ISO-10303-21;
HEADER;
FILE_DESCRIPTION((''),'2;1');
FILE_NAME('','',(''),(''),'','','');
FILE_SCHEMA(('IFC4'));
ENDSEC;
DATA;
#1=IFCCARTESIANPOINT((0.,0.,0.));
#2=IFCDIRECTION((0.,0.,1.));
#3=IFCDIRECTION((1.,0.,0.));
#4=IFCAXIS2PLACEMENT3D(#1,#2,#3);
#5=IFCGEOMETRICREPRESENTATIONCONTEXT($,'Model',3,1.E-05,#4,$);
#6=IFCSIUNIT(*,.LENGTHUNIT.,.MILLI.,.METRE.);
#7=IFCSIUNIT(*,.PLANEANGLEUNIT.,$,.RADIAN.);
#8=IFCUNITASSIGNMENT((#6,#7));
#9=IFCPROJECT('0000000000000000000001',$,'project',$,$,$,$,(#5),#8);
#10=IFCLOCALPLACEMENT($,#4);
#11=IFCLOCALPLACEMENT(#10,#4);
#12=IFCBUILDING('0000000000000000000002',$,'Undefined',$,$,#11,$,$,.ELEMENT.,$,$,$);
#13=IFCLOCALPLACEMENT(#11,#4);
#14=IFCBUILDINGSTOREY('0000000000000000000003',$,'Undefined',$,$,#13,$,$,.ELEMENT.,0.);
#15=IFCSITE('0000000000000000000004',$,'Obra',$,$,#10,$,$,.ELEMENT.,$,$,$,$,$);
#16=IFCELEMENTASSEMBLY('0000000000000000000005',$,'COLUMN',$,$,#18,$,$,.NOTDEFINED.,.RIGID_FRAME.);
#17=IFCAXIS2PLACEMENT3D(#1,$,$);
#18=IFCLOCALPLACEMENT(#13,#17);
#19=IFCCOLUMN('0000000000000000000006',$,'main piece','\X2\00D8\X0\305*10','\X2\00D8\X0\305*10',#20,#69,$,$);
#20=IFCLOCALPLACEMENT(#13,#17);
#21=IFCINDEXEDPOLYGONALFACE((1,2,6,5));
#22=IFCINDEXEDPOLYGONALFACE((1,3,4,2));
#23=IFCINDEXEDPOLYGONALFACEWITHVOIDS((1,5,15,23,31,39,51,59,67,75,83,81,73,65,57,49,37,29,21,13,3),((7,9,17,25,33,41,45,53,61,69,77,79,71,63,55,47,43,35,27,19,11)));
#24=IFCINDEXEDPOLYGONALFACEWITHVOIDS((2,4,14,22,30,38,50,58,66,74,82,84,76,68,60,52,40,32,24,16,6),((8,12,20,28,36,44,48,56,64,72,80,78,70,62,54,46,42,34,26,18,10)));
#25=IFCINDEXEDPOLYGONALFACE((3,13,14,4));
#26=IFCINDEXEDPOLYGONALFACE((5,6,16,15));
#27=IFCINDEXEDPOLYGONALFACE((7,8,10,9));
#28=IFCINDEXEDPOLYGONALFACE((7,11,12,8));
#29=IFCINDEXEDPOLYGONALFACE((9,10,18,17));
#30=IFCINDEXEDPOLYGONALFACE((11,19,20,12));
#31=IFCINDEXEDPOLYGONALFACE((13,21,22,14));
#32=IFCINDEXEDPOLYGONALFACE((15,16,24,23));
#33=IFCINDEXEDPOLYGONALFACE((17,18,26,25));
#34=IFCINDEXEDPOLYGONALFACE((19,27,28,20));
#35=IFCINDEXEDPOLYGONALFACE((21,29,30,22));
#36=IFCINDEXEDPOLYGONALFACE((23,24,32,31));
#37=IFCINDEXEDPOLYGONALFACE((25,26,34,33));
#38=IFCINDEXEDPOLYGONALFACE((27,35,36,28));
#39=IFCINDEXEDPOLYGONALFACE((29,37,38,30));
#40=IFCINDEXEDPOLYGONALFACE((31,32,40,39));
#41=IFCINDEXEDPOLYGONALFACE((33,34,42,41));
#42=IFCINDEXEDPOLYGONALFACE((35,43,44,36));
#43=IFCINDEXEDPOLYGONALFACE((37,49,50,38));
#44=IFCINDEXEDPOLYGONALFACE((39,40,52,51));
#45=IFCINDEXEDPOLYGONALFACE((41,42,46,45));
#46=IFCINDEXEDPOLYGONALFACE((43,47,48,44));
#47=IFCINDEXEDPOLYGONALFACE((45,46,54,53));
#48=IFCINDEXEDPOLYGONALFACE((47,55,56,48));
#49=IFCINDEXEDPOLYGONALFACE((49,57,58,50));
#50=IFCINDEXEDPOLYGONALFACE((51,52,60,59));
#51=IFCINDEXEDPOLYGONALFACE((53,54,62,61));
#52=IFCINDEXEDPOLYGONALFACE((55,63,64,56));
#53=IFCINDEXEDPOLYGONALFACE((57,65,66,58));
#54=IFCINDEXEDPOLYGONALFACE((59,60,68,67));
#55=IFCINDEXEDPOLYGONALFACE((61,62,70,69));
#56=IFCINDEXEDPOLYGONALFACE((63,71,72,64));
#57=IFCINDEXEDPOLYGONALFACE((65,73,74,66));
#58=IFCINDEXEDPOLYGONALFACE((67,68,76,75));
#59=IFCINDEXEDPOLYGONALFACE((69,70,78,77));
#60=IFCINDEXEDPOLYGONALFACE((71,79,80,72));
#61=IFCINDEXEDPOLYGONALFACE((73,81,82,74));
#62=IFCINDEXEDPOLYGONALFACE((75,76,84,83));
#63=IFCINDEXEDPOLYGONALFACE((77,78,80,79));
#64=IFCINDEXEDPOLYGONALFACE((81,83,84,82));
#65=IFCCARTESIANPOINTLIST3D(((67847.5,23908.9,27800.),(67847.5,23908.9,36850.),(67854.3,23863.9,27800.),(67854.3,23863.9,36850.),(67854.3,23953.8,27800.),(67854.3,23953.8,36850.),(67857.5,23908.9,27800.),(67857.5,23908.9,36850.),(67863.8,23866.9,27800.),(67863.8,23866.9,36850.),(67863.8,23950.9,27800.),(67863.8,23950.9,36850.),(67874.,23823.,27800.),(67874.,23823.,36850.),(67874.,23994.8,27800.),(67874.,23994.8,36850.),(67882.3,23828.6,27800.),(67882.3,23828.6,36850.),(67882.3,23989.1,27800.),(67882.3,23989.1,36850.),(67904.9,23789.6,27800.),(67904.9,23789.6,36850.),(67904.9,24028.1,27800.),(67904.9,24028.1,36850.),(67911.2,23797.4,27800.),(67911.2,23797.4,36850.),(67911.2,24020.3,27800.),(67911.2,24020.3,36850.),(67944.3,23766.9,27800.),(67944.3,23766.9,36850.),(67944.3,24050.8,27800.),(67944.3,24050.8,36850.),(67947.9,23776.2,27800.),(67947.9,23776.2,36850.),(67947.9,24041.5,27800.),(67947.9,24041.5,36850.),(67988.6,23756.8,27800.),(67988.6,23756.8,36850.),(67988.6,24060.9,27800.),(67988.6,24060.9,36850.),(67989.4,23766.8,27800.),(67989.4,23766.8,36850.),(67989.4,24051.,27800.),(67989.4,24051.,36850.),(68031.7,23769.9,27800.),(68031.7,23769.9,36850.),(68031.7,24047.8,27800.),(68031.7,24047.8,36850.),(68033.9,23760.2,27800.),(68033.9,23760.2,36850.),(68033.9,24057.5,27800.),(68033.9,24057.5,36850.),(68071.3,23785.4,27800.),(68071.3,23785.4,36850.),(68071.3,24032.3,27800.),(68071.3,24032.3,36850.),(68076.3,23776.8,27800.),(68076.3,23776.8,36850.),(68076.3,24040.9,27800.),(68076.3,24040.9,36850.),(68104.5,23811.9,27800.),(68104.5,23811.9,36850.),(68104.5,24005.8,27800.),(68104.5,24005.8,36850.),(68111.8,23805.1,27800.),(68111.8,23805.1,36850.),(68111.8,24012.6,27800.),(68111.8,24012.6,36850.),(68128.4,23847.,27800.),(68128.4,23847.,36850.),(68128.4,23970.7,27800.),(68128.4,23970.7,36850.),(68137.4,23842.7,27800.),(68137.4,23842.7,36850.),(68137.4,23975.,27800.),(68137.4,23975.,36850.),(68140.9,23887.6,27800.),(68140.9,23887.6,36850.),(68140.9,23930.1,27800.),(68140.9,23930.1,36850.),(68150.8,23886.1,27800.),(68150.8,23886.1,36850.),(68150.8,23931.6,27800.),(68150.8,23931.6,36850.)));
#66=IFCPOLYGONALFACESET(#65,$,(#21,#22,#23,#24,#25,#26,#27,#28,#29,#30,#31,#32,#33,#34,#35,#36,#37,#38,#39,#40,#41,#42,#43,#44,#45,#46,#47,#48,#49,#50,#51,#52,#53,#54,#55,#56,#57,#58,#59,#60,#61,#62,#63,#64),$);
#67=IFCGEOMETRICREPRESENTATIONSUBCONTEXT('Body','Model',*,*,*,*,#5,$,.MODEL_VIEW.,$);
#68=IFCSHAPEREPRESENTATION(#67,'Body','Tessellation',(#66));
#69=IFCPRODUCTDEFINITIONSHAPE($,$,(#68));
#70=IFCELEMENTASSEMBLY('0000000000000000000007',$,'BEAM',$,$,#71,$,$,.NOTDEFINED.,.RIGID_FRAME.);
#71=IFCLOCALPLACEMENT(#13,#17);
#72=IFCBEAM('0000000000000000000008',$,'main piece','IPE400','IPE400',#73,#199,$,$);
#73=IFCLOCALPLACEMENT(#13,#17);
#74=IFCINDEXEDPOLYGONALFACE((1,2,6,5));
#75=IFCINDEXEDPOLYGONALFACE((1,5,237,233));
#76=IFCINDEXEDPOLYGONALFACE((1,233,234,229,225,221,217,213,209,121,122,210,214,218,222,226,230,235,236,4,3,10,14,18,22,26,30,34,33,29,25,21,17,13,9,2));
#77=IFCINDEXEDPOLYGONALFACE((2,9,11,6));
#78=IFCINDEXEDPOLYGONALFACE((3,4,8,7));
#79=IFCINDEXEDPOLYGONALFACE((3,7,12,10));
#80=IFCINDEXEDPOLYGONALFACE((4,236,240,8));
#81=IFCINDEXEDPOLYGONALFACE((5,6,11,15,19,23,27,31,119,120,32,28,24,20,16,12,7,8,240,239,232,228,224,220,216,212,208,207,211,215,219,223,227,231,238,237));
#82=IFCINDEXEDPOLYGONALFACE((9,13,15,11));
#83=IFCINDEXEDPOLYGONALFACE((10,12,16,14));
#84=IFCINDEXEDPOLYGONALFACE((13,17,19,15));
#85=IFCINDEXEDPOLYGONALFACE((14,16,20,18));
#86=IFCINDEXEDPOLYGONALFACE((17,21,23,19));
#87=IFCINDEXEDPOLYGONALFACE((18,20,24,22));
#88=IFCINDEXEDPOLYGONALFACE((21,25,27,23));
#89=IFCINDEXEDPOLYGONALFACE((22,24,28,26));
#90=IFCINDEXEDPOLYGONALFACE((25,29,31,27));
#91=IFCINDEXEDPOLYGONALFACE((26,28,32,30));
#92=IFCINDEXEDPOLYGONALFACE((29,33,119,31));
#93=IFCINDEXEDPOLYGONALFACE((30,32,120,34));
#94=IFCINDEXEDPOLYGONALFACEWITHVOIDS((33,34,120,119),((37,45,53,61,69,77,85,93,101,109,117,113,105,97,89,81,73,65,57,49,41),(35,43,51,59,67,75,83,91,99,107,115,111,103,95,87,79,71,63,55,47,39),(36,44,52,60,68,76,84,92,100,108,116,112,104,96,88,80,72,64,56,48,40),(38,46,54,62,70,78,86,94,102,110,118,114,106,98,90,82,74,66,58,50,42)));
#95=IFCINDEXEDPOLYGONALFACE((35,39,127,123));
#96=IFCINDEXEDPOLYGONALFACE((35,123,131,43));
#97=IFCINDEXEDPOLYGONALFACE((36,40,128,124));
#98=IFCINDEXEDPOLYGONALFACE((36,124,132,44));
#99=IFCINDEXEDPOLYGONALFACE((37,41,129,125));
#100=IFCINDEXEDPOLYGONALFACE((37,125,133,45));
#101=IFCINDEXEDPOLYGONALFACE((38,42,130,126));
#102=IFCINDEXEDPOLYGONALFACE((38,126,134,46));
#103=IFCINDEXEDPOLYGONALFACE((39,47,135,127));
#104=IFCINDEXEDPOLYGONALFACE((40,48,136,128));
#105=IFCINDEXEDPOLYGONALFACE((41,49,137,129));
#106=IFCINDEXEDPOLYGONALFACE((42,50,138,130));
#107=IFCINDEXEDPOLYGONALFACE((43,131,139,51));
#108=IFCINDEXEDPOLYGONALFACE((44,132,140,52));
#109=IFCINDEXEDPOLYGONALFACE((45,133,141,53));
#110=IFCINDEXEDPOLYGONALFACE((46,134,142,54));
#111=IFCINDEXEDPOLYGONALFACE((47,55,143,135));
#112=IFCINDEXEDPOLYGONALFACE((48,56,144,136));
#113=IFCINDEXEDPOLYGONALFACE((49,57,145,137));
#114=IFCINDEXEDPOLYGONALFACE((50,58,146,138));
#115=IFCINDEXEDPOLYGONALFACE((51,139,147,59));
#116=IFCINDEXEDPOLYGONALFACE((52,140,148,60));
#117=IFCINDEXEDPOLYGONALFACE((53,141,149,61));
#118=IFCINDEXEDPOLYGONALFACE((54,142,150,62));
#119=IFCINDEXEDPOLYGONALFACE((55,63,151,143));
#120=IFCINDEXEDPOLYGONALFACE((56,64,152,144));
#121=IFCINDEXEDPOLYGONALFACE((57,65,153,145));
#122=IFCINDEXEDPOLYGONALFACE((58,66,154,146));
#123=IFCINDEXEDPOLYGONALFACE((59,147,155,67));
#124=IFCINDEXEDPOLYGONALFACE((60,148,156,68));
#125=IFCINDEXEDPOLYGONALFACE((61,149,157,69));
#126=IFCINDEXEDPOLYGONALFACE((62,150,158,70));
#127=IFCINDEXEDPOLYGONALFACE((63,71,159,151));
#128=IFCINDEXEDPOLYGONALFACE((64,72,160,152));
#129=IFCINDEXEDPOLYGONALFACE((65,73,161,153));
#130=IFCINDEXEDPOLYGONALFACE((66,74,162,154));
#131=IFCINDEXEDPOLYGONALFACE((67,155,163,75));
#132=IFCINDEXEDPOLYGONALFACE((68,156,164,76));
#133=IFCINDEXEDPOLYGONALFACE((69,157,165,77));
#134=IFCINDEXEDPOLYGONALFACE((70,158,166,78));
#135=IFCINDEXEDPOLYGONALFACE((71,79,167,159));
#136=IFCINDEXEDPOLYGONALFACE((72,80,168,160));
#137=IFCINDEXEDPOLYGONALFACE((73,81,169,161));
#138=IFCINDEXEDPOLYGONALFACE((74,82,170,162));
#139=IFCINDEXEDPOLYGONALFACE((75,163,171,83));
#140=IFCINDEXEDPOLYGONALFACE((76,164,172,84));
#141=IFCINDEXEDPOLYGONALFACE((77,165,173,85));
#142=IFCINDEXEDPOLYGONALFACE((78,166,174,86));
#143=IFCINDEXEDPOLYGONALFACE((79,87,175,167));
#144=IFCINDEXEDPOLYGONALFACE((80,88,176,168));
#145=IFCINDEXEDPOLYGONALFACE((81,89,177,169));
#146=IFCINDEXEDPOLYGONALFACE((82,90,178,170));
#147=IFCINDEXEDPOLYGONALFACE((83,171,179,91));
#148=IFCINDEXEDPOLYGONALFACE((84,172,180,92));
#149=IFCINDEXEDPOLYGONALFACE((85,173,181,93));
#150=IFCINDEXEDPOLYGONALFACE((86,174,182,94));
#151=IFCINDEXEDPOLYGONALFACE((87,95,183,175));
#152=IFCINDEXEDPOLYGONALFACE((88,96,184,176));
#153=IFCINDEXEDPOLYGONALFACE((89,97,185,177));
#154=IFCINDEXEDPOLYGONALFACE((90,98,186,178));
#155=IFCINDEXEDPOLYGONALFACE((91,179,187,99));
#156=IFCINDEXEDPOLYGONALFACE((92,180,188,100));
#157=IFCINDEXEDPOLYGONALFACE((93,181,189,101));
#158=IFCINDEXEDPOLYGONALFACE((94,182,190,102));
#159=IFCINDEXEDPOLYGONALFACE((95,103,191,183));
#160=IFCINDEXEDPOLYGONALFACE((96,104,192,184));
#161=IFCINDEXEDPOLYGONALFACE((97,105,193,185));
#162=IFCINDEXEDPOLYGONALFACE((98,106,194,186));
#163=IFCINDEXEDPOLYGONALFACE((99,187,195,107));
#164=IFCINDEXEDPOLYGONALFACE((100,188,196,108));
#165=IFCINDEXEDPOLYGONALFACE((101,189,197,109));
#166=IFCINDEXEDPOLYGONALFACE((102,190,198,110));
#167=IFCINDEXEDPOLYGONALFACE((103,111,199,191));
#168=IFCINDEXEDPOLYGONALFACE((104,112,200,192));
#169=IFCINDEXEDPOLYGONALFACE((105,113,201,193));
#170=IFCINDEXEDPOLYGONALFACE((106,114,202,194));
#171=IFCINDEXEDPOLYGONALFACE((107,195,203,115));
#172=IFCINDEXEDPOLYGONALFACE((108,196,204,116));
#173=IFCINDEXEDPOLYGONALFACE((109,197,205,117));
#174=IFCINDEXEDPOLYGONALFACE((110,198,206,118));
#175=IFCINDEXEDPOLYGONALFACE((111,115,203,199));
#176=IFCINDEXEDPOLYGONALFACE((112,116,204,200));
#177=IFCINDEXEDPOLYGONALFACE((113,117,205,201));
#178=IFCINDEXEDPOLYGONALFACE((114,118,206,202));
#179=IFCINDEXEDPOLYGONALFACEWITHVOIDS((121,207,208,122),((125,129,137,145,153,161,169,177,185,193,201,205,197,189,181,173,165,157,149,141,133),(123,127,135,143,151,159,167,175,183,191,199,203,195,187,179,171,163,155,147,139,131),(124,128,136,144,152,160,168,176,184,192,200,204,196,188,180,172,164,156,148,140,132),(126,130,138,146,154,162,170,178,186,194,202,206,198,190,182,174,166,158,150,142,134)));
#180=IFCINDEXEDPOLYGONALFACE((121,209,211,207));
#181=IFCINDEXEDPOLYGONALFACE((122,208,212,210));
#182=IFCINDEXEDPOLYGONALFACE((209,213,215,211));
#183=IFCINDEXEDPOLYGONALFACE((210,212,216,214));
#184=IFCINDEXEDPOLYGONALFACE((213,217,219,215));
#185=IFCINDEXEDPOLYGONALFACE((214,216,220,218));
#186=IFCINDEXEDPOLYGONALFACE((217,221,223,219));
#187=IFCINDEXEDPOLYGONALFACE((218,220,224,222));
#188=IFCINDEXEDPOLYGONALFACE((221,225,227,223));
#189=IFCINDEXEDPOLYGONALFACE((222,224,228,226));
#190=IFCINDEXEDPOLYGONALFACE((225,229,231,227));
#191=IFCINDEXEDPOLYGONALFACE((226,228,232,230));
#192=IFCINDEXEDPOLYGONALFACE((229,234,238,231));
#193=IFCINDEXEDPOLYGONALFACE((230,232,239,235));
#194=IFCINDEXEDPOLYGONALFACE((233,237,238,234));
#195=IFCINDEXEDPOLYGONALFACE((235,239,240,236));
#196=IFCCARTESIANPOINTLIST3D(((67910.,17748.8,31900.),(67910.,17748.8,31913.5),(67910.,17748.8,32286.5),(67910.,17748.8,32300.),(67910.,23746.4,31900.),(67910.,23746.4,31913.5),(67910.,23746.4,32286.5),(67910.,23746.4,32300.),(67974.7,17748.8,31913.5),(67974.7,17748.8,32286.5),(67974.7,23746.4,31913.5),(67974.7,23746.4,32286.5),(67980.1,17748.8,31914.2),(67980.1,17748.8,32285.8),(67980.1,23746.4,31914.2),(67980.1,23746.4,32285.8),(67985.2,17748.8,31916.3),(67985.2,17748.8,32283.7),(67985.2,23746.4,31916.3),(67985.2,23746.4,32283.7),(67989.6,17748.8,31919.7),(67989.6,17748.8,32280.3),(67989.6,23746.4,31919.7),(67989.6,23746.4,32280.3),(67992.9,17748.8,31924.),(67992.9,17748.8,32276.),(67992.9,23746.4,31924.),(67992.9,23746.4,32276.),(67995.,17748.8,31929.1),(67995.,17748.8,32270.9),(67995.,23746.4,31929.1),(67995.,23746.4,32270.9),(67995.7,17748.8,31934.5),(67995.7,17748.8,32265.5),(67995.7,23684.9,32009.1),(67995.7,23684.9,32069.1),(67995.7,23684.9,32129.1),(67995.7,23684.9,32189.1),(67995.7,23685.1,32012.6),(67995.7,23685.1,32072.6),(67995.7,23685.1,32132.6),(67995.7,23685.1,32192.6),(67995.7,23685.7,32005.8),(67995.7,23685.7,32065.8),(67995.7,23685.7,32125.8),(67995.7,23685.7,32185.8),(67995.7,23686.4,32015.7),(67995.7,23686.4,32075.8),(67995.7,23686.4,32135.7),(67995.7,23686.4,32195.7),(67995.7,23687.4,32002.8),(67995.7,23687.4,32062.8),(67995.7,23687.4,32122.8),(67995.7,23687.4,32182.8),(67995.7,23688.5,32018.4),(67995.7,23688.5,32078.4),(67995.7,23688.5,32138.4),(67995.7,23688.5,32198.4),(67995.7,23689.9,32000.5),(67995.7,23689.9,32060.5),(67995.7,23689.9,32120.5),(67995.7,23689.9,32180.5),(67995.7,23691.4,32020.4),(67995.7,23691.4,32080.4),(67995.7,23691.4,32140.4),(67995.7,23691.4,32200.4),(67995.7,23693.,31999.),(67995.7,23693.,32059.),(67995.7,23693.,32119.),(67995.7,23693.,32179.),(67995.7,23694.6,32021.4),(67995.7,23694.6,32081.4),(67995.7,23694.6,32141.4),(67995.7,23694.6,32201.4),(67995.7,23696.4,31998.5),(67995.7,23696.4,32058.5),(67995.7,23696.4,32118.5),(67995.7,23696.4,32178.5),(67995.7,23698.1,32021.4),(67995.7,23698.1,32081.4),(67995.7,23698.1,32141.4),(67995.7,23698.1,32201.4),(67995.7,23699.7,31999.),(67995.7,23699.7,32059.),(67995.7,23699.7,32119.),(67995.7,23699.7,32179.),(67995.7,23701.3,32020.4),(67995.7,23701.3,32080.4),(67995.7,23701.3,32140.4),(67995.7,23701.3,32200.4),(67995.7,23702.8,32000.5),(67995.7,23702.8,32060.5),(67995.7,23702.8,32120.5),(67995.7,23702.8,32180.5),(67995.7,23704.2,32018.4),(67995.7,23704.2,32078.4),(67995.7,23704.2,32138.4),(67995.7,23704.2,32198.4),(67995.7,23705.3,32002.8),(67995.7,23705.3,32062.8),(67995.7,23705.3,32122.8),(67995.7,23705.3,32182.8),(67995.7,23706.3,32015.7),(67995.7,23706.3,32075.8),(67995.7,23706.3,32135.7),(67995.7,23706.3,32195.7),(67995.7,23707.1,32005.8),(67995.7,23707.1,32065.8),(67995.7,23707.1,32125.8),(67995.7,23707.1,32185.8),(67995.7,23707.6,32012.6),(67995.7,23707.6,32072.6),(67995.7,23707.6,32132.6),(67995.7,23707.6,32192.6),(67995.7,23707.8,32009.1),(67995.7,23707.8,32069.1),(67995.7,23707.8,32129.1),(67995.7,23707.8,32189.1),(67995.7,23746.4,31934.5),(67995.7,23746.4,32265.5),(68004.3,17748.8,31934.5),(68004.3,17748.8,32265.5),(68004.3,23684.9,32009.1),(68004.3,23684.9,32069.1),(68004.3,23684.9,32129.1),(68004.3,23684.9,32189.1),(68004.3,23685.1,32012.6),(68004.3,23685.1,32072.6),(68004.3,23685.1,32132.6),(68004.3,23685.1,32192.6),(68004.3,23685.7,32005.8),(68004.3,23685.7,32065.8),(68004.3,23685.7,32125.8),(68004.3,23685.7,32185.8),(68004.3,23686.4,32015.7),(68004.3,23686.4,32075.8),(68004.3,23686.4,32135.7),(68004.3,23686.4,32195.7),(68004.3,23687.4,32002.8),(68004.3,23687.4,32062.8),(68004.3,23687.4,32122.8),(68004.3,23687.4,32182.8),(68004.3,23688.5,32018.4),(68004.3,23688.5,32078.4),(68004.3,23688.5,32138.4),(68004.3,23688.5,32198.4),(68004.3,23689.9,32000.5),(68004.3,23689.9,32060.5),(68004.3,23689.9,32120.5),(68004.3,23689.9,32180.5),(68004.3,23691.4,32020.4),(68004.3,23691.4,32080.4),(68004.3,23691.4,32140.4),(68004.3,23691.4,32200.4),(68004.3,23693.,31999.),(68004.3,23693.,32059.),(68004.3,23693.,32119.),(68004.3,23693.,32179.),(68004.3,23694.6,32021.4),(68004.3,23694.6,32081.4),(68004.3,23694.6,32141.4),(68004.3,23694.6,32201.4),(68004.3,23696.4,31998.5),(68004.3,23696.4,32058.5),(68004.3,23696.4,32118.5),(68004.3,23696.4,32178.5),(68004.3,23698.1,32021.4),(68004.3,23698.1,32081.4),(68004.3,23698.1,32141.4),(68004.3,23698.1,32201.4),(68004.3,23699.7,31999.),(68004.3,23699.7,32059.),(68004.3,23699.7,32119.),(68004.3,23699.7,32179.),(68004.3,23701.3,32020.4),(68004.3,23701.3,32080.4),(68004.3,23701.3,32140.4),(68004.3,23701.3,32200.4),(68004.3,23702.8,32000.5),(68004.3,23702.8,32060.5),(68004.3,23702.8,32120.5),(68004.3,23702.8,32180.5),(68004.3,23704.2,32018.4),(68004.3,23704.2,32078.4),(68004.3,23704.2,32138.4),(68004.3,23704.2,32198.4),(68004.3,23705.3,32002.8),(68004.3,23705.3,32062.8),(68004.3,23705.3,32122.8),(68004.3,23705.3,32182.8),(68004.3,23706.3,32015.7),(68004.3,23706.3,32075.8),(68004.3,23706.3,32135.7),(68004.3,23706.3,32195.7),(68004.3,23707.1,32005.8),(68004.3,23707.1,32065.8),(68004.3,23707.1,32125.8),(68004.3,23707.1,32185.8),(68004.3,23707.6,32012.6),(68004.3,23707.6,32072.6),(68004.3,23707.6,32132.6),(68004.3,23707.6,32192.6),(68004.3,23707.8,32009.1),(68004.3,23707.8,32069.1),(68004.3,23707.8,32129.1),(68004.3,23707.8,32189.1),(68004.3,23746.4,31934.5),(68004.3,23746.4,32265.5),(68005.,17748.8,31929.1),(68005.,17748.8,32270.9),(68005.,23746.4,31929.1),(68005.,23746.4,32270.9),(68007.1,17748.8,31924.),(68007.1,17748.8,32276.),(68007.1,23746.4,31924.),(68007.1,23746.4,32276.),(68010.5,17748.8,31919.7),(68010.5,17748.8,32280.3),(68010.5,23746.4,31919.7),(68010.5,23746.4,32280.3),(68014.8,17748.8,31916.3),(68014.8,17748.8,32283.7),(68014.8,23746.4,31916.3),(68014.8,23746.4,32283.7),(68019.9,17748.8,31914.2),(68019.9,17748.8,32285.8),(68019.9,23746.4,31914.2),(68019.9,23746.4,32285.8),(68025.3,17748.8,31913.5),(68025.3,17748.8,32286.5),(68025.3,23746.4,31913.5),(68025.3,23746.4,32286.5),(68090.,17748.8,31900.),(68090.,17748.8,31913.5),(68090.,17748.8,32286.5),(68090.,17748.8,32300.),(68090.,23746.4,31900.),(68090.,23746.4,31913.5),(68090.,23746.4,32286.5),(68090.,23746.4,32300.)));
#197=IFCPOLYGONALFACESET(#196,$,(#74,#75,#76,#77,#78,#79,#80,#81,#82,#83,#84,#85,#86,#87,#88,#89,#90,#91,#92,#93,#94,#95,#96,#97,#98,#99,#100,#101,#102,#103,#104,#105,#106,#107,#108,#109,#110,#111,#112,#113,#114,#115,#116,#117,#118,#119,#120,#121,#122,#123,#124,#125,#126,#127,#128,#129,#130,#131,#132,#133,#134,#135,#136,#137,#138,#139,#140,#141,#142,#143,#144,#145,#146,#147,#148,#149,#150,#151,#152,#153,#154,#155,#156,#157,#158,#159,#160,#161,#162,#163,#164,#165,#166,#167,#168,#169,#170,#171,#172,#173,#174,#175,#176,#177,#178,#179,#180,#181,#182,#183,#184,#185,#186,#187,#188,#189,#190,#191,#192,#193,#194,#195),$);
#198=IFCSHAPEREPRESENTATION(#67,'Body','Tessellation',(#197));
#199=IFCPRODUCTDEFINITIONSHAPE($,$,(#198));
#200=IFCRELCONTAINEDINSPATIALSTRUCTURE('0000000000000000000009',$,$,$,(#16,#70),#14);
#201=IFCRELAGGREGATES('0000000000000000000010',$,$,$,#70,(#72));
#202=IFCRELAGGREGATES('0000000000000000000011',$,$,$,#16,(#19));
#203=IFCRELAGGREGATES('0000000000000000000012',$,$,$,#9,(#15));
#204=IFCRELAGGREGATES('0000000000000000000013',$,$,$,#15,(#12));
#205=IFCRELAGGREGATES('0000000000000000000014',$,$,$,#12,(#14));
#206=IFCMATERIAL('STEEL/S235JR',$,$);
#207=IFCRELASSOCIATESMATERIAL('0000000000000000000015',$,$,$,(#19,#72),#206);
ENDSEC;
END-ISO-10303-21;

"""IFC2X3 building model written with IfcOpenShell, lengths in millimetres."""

from ifc_helpers import new_model, si_unit, frame, origin_with_axes, origin_2d_with_axis, place, context, subcontext, project, spatial, circle, hollow_circle, i_section, extrude, clip, halfspace, source, transform, mapped, material, element, aggregate, save


model = new_model("IFC2X3")

# Units and contexts
model_context = context("Model", 3, precision=1e-05, world=origin_with_axes())
body_context = subcontext(model_context, "Body", "Model", "MODEL_VIEW")
ifc_project = project(units=[si_unit("LENGTHUNIT", "METRE", prefix="MILLI"), si_unit("PLANEANGLEUNIT", "RADIAN")], contexts=[model_context])

# Site, building, storey
site_placement = place(None, origin_with_axes())
site = spatial("IfcSite", under=ifc_project, at=site_placement, Name="Obra", CompositionType="ELEMENT")
building_placement = place(site_placement, origin_with_axes())
building = spatial("IfcBuilding", under=site, at=building_placement, Name="Undefined", CompositionType="ELEMENT")
storey_placement = place(building_placement, origin_with_axes())
storey = spatial("IfcBuildingStorey", under=building, at=storey_placement, Name="Undefined", CompositionType="ELEMENT", Elevation=0.0)

# Element assembly, column
assembly_1_placement = place(storey_placement, origin_with_axes())
assembly_1 = element("IfcElementAssembly", 1, at=assembly_1_placement, inside=storey, Name="COLUMN", AssemblyPlace="NOTDEFINED", PredefinedType="RIGID_FRAME")
ifc_material_1 = material(Name="STEEL/S235JR")
column_placement = place(assembly_1_placement, frame((68000.0, 23908.9, 27800.0), z_axis=(0.0, 0.0, 1.0), x_axis=(0.0, 1.0, 0.0)))
column = element("IfcColumn", 2, at=column_placement, material=ifc_material_1, Name="main piece", Description="Ø305*10", ObjectType="Ø305*10", context=body_context, shape_type="SweptSolid", body=[
    extrude(hollow_circle(Radius=152.5, WallThickness=10.0, at=origin_2d_with_axis()), frame((0.0, 0.0, 9050.0), z_axis=(0.0, 0.0, -1.0), x_axis=(0.0, 1.0, 0.0)), (0.0, 0.0, 1.0), 9050.0),
])

# Shared definitions
shared_shape_1 = source(origin_with_axes(), body_context, "Body", "SweptSolid", [
    extrude(circle(Radius=11.5, at=origin_2d_with_axis()), frame((0.0, -4.4, 0.0), z_axis=(0.0, 1.0, 0.0), x_axis=(1.0, 0.0, 0.0)), (0.0, 0.0, 1.0), 8.8),
])

# Element assembly, beam, opening
assembly_2_placement = place(storey_placement, origin_with_axes())
assembly_2 = element("IfcElementAssembly", 3, at=assembly_2_placement, inside=storey, Name="BEAM", AssemblyPlace="NOTDEFINED", PredefinedType="RIGID_FRAME")
beam_1_placement = place(assembly_2_placement, frame((68000.0, 23736.6, 32100.0), z_axis=(0.0, 0.0, 1.0), x_axis=(0.0, -1.0, 0.0)))
beam_1 = element("IfcBeam", 4, at=beam_1_placement, material=ifc_material_1, Name="main piece", Description="IPE400", ObjectType="IPE400", context=body_context, shape_type="Clipping", body=[
    clip(extrude(i_section(OverallWidth=180.0, OverallDepth=400.0, WebThickness=8.6, FlangeThickness=13.5, FilletRadius=21.0, at=origin_2d_with_axis()), frame((5987.7, 0.0, 0.0), z_axis=(-1.0, 0.0, 0.0), x_axis=(0.0, -1.0, 0.0)), (0.0, 0.0, 1.0), 5997.5), halfspace(frame((-9.8, 0.0, -300.0), z_axis=(1.0, 0.0, 0.0), x_axis=(0.0, -1.0, 0.0)), True)),
])
opening_1_placement = place(assembly_2_placement, frame((68000.0, 23746.4, 32300.0), z_axis=(0.0, -1.0, 0.0), x_axis=(0.0, 0.0, -1.0)))
element("IfcOpeningElement", 5, at=opening_1_placement, cuts=beam_1, ObjectType="Opening", context=body_context, shape_type="MappedRepresentation", body=[
    mapped(shared_shape_1, transform((110.0, 0.0, 50.0))),
    mapped(shared_shape_1, transform((170.0, 0.0, 50.0))),
    mapped(shared_shape_1, transform((230.0, 0.0, 50.0))),
    mapped(shared_shape_1, transform((290.0, 0.0, 50.0))),
])

aggregate(assembly_2, [beam_1])
aggregate(assembly_1, [column])

save(model, "model.ifc")
